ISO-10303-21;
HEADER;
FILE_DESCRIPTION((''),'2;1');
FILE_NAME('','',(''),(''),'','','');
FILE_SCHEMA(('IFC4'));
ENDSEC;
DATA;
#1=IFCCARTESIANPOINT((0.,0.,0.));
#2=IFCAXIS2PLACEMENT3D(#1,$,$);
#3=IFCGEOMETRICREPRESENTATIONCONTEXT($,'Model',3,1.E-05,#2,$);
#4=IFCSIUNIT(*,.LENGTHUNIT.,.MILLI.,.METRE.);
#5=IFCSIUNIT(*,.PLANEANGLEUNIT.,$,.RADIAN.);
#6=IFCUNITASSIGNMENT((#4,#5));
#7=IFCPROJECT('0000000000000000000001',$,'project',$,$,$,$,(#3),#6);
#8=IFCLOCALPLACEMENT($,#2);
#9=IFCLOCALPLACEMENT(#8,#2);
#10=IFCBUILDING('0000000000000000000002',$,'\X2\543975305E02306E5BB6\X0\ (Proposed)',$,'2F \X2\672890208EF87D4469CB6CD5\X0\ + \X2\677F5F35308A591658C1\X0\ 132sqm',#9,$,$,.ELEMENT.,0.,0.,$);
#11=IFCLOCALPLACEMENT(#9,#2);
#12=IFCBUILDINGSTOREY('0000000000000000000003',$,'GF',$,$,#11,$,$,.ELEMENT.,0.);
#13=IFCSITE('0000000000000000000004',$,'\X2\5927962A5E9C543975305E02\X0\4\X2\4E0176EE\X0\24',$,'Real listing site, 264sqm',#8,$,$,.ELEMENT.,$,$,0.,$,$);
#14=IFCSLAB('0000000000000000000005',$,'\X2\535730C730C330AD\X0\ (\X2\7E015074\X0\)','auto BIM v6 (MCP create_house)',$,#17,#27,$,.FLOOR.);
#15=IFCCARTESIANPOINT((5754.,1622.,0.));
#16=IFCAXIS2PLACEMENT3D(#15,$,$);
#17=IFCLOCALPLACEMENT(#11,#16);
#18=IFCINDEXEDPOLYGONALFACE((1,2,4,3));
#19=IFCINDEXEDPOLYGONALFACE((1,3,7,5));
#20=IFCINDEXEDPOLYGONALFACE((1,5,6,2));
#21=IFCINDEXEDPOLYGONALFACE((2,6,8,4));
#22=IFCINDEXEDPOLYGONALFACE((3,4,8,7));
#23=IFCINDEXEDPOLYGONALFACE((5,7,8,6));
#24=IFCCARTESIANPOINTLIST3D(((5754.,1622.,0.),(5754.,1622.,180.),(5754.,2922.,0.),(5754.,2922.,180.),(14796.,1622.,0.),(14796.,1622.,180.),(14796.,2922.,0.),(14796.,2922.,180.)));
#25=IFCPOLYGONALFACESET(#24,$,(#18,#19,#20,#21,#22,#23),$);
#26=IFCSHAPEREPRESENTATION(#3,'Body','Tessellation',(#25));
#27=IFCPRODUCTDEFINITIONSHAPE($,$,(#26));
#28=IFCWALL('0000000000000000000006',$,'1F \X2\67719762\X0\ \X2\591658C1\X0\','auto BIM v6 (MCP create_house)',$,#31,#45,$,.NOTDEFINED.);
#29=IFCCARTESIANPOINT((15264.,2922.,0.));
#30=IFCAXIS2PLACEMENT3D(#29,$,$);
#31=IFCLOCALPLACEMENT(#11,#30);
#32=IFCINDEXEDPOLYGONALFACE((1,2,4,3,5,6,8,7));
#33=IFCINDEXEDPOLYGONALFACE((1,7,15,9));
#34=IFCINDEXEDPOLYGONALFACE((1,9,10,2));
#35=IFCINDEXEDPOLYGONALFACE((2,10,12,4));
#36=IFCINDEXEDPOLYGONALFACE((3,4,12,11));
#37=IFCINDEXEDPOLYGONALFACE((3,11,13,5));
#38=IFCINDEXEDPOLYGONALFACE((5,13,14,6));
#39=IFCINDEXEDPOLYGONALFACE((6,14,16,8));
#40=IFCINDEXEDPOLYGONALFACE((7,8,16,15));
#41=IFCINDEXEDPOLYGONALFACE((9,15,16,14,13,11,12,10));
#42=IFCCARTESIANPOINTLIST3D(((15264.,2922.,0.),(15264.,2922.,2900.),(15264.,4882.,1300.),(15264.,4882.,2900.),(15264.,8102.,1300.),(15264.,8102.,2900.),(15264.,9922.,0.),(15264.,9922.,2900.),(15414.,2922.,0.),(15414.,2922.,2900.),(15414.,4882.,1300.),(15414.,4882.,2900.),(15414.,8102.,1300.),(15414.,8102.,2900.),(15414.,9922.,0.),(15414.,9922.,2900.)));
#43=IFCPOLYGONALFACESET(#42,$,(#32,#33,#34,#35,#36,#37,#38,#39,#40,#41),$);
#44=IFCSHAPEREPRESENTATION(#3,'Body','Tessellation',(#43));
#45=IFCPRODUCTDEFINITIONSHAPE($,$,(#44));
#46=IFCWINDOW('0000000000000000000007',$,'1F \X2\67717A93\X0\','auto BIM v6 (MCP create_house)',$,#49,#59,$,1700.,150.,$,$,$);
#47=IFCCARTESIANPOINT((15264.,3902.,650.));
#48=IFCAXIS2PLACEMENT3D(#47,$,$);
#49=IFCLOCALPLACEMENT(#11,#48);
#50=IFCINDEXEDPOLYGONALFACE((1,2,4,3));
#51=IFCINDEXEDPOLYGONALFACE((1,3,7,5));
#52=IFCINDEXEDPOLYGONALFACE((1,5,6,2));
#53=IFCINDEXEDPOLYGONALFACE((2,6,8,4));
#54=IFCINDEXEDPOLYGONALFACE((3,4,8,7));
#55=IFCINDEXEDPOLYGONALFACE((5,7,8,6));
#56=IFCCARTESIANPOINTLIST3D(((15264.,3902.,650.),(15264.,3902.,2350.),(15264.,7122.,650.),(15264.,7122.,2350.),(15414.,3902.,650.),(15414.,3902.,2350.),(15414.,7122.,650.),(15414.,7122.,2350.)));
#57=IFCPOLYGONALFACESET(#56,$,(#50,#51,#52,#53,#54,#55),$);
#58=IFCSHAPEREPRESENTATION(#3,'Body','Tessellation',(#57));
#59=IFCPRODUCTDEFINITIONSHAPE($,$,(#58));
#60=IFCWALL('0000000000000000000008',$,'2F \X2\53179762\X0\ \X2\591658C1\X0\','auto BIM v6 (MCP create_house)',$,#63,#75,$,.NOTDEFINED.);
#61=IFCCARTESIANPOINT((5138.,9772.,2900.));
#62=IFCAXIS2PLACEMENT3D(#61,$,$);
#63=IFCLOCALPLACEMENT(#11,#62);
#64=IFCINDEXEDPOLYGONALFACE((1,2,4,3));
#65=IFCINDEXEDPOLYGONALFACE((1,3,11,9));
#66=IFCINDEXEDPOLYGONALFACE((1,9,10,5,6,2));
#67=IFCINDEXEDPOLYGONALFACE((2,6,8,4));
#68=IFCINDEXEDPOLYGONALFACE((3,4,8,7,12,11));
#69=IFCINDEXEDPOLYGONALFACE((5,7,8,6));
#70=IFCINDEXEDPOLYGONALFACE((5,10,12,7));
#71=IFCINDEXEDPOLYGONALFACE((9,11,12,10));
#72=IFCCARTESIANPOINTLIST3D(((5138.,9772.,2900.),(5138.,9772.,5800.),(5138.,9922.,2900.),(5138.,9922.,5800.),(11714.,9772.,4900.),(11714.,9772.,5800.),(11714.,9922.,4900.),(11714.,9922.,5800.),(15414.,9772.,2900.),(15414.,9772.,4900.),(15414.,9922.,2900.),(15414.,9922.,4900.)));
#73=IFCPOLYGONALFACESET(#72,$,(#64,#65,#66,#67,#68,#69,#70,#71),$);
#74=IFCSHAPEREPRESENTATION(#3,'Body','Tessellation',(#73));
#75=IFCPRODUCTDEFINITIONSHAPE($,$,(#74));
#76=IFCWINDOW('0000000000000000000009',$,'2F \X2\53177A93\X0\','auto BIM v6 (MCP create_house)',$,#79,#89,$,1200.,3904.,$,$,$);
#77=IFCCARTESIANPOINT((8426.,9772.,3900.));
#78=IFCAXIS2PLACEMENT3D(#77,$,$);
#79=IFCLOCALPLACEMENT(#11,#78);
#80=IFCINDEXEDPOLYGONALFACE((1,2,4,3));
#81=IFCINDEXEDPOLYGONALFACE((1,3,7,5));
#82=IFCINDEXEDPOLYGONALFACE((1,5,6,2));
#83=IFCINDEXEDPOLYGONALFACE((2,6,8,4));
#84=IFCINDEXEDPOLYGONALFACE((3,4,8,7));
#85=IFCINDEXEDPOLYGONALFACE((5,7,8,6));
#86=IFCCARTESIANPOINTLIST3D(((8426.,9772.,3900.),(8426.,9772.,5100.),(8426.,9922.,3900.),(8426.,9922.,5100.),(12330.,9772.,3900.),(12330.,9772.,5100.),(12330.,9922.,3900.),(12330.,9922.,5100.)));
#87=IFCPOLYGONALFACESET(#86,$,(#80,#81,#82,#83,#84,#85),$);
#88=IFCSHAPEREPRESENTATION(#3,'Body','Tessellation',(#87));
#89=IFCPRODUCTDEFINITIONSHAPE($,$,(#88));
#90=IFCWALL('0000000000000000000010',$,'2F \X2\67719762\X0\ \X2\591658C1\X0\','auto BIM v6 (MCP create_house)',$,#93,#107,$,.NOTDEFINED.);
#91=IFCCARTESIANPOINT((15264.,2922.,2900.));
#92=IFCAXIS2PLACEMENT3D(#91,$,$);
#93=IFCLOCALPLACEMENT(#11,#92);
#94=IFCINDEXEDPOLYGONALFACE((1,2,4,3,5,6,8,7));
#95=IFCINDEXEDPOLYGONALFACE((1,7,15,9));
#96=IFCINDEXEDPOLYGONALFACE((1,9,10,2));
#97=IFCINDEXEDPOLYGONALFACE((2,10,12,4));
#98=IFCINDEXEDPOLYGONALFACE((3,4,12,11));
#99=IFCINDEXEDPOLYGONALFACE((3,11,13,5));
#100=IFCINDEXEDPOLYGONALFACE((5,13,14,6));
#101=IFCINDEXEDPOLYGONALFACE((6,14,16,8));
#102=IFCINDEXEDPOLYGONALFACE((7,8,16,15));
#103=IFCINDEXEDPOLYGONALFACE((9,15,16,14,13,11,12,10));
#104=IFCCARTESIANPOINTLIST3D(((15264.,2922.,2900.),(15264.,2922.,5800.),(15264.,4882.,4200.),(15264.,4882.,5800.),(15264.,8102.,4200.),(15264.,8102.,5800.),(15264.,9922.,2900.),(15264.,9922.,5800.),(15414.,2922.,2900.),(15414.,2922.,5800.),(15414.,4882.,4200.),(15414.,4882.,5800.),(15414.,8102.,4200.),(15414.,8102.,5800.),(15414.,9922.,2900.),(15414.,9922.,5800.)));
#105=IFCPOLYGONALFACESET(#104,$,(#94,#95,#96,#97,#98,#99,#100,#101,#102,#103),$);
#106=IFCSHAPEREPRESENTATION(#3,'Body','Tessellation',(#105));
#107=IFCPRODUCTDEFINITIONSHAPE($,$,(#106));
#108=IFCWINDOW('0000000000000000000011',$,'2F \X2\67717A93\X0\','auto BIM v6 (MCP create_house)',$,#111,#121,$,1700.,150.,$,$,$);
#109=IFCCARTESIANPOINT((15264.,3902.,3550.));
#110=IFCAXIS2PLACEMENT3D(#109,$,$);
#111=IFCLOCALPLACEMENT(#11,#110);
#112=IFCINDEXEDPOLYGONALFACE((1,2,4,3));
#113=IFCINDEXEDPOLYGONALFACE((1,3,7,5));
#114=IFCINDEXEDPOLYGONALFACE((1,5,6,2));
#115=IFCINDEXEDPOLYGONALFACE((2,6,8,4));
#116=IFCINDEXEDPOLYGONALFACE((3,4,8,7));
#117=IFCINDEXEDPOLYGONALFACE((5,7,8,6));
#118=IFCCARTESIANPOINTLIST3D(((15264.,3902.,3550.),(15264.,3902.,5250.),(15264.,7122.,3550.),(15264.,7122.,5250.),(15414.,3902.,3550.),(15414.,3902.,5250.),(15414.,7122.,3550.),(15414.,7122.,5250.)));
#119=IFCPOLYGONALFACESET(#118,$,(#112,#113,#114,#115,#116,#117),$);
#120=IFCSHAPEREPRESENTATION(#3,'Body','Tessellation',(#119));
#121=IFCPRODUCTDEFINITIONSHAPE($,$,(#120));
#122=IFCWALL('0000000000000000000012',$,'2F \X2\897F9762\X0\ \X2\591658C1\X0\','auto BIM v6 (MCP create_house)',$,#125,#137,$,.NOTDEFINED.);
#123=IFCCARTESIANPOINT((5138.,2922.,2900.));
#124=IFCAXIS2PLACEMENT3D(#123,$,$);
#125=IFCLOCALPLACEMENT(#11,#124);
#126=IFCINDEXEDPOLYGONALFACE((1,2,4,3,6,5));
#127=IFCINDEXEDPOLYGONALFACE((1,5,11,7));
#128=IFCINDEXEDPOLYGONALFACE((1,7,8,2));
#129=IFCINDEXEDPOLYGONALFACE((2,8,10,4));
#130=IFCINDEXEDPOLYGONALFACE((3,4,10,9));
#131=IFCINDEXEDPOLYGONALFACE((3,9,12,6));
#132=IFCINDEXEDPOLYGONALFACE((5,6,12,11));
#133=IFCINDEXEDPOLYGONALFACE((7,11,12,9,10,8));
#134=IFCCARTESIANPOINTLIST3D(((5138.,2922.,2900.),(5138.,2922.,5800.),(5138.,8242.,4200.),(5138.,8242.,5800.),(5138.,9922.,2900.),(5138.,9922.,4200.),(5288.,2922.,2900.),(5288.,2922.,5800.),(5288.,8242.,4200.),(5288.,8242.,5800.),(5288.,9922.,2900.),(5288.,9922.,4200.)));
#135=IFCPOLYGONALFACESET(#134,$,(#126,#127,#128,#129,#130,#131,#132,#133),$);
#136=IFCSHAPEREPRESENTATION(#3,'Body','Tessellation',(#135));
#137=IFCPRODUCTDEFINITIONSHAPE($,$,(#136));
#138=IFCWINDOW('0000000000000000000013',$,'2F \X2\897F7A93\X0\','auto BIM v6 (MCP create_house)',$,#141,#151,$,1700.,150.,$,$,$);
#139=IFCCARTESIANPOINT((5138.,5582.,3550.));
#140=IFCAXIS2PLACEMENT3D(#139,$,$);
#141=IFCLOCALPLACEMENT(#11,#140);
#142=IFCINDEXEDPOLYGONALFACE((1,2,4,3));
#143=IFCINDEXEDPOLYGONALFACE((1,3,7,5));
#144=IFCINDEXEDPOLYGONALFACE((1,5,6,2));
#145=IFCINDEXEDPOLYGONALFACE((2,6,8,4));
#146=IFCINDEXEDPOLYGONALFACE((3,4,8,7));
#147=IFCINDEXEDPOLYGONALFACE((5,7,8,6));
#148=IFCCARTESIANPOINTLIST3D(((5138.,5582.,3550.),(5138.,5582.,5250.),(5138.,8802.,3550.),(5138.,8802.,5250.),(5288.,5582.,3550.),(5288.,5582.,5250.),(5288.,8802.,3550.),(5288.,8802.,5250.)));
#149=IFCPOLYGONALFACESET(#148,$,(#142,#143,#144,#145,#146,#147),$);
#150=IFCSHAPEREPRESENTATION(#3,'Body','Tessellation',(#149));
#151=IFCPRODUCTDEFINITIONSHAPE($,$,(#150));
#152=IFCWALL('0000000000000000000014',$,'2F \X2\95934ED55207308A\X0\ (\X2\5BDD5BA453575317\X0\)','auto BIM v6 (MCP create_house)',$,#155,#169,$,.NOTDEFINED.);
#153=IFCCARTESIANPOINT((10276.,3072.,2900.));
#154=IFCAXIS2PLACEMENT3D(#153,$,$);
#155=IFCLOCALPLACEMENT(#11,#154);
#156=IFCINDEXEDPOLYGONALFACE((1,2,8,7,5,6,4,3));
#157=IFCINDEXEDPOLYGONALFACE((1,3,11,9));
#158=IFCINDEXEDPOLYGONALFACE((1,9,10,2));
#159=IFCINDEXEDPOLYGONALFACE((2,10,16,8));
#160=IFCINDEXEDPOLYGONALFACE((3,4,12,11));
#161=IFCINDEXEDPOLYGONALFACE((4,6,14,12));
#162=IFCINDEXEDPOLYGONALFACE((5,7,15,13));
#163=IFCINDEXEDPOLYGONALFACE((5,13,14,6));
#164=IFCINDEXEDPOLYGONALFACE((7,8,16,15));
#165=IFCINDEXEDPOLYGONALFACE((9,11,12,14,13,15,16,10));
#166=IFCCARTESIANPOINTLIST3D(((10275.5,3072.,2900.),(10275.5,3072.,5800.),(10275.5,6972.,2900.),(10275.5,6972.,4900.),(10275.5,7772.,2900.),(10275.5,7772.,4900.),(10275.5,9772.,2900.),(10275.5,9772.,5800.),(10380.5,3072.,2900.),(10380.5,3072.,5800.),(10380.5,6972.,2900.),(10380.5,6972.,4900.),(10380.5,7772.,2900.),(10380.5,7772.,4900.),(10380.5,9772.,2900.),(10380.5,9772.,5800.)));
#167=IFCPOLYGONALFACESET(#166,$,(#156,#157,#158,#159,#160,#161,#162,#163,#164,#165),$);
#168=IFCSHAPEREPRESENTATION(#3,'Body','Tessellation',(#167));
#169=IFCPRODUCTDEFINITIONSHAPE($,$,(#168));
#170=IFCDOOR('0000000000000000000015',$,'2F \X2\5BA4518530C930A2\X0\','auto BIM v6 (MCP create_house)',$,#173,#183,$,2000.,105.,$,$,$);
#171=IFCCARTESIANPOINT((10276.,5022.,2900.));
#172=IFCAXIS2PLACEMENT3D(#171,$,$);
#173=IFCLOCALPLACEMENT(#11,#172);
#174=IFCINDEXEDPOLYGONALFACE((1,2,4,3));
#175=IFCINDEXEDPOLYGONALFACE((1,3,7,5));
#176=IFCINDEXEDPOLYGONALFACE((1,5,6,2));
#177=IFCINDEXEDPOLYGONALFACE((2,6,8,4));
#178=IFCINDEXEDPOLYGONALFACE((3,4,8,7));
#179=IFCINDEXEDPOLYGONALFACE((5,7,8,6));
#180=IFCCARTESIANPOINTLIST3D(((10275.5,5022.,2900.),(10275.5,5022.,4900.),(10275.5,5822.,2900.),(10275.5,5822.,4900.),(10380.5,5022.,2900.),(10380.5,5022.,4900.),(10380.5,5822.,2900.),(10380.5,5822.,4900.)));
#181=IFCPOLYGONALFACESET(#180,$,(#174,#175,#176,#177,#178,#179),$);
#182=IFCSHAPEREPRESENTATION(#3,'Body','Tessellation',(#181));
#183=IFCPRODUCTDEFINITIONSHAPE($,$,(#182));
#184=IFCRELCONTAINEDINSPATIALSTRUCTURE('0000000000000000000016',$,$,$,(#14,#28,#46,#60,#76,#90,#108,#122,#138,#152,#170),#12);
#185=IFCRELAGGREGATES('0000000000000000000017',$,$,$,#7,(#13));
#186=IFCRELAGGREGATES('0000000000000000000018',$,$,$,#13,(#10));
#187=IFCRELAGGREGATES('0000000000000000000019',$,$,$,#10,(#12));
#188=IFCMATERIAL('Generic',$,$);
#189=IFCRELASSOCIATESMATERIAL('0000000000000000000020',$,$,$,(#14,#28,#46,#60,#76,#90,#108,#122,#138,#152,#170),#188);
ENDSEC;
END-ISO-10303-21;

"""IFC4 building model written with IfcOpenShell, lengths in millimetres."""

from ifc_helpers import new_model, si_unit, frame, frame_2d, origin, place, context, project, spatial, rectangle, extrude, material, element, fill, save


model = new_model("IFC4")

# Units and contexts
model_context = context("Model", 3, precision=1e-05, world=origin())
ifc_project = project(units=[si_unit("LENGTHUNIT", "METRE", prefix="MILLI"), si_unit("PLANEANGLEUNIT", "RADIAN")], contexts=[model_context])

# Site, building, storey
site_placement = place(None, origin())
site = spatial("IfcSite", under=ifc_project, at=site_placement, Name="大阪府吹田市4丁目24", ObjectType="Real listing site, 264sqm", CompositionType="ELEMENT", RefElevation=0.0)
building_placement = place(site_placement, origin())
building = spatial("IfcBuilding", under=site, at=building_placement, Name="吹田市の家 (Proposed)", ObjectType="2F 木造軸組構法 + 板張り外壁 132sqm", CompositionType="ELEMENT", ElevationOfRefHeight=0.0, ElevationOfTerrain=0.0)
storey_placement = place(building_placement, origin())
storey = spatial("IfcBuildingStorey", under=building, at=storey_placement, Name="GF", CompositionType="ELEMENT", Elevation=0.0)

# Slab
ifc_material = material(Name="Generic")
slab_placement = place(storey_placement, frame((5754.0, 1622.0, 0.0)))
element("IfcSlab", 1, at=slab_placement, inside=storey, material=ifc_material, Name="南デッキ (縁側)", Description="auto BIM v6 (MCP create_house)", PredefinedType="FLOOR", context=model_context, shape_type="SweptSolid", body=[
    extrude(rectangle(XDim=9042.0, YDim=1300.0, at=frame_2d((4521.0, 650.0))), frame((5754.0, 1622.0, 0.0)), (0.0, 0.0, 1.0), 180.0),
])

# Wall, opening, window
wall_1_placement = place(storey_placement, frame((15264.0, 2922.0, 0.0)))
wall_1 = element("IfcWall", 2, at=wall_1_placement, inside=storey, material=ifc_material, Name="1F 東面 外壁", Description="auto BIM v6 (MCP create_house)", PredefinedType="NOTDEFINED", context=model_context, shape_type="SweptSolid", body=[
    extrude(rectangle(XDim=150.0, YDim=7000.0, at=frame_2d((75.0, 3500.0))), frame((15264.0, 2922.0, 0.0)), (0.0, 0.0, 1.0), 2900.0),
])
opening_1_placement = place(storey_placement, frame((15264.0, 3902.0, 650.0)))
opening_1 = element("IfcOpeningElement", 3, at=opening_1_placement, cuts=wall_1, PredefinedType="NOTDEFINED", context=model_context, shape_type="SweptSolid", body=[
    extrude(rectangle(XDim=150.0, YDim=3220.0, at=frame_2d((75.0, 1610.0))), frame((15264.0, 3902.0, 650.0)), (0.0, 0.0, 1.0), 1700.0),
])
window_1_placement = place(storey_placement, frame((15264.0, 3902.0, 650.0)))
window_1 = element("IfcWindow", 4, at=window_1_placement, inside=storey, material=ifc_material, Name="1F 東窓", Description="auto BIM v6 (MCP create_house)", OverallHeight=1700.0, OverallWidth=150.0, context=model_context, shape_type="SweptSolid", body=[
    extrude(rectangle(XDim=150.0, YDim=3220.0, at=frame_2d((75.0, 1610.0))), frame((15264.0, 3902.0, 650.0)), (0.0, 0.0, 1.0), 1700.0),
])
fill(opening_1, window_1)

# Walls, openings, windows
wall_2_placement = place(storey_placement, frame((5138.0, 9772.0, 2900.0)))
wall_2 = element("IfcWall", 5, at=wall_2_placement, inside=storey, material=ifc_material, Name="2F 北面 外壁", Description="auto BIM v6 (MCP create_house)", PredefinedType="NOTDEFINED", context=model_context, shape_type="SweptSolid", body=[
    extrude(rectangle(XDim=10276.0, YDim=150.0, at=frame_2d((5138.0, 75.0))), frame((5138.0, 9772.0, 2900.0)), (0.0, 0.0, 1.0), 2900.0),
])
opening_2_placement = place(storey_placement, frame((8426.0, 9772.0, 3900.0)))
opening_2 = element("IfcOpeningElement", 6, at=opening_2_placement, cuts=wall_2, PredefinedType="NOTDEFINED", context=model_context, shape_type="SweptSolid", body=[
    extrude(rectangle(XDim=3904.0, YDim=150.0, at=frame_2d((1952.0, 75.0))), frame((8426.0, 9772.0, 3900.0)), (0.0, 0.0, 1.0), 1200.0),
])
window_2_placement = place(storey_placement, frame((8426.0, 9772.0, 3900.0)))
window_2 = element("IfcWindow", 7, at=window_2_placement, inside=storey, material=ifc_material, Name="2F 北窓", Description="auto BIM v6 (MCP create_house)", OverallHeight=1200.0, OverallWidth=3904.0, context=model_context, shape_type="SweptSolid", body=[
    extrude(rectangle(XDim=3904.0, YDim=150.0, at=frame_2d((1952.0, 75.0))), frame((8426.0, 9772.0, 3900.0)), (0.0, 0.0, 1.0), 1200.0),
])
fill(opening_2, window_2)
wall_3_placement = place(storey_placement, frame((15264.0, 2922.0, 2900.0)))
wall_3 = element("IfcWall", 8, at=wall_3_placement, inside=storey, material=ifc_material, Name="2F 東面 外壁", Description="auto BIM v6 (MCP create_house)", PredefinedType="NOTDEFINED", context=model_context, shape_type="SweptSolid", body=[
    extrude(rectangle(XDim=150.0, YDim=7000.0, at=frame_2d((75.0, 3500.0))), frame((15264.0, 2922.0, 2900.0)), (0.0, 0.0, 1.0), 2900.0),
])
opening_3_placement = place(storey_placement, frame((15264.0, 3902.0, 3550.0)))
opening_3 = element("IfcOpeningElement", 9, at=opening_3_placement, cuts=wall_3, PredefinedType="NOTDEFINED", context=model_context, shape_type="SweptSolid", body=[
    extrude(rectangle(XDim=150.0, YDim=3220.0, at=frame_2d((75.0, 1610.0))), frame((15264.0, 3902.0, 3550.0)), (0.0, 0.0, 1.0), 1700.0),
])
window_3_placement = place(storey_placement, frame((15264.0, 3902.0, 3550.0)))
window_3 = element("IfcWindow", 10, at=window_3_placement, inside=storey, material=ifc_material, Name="2F 東窓", Description="auto BIM v6 (MCP create_house)", OverallHeight=1700.0, OverallWidth=150.0, context=model_context, shape_type="SweptSolid", body=[
    extrude(rectangle(XDim=150.0, YDim=3220.0, at=frame_2d((75.0, 1610.0))), frame((15264.0, 3902.0, 3550.0)), (0.0, 0.0, 1.0), 1700.0),
])
fill(opening_3, window_3)
wall_4_placement = place(storey_placement, frame((5138.0, 2922.0, 2900.0)))
wall_4 = element("IfcWall", 11, at=wall_4_placement, inside=storey, material=ifc_material, Name="2F 西面 外壁", Description="auto BIM v6 (MCP create_house)", PredefinedType="NOTDEFINED", context=model_context, shape_type="SweptSolid", body=[
    extrude(rectangle(XDim=150.0, YDim=7000.0, at=frame_2d((75.0, 3500.0))), frame((5138.0, 2922.0, 2900.0)), (0.0, 0.0, 1.0), 2900.0),
])
opening_4_placement = place(storey_placement, frame((5138.0, 5582.0, 3550.0)))
opening_4 = element("IfcOpeningElement", 12, at=opening_4_placement, cuts=wall_4, PredefinedType="NOTDEFINED", context=model_context, shape_type="SweptSolid", body=[
    extrude(rectangle(XDim=150.0, YDim=3220.0, at=frame_2d((75.0, 1610.0))), frame((5138.0, 5582.0, 3550.0)), (0.0, 0.0, 1.0), 1700.0),
])
window_4_placement = place(storey_placement, frame((5138.0, 5582.0, 3550.0)))
window_4 = element("IfcWindow", 13, at=window_4_placement, inside=storey, material=ifc_material, Name="2F 西窓", Description="auto BIM v6 (MCP create_house)", OverallHeight=1700.0, OverallWidth=150.0, context=model_context, shape_type="SweptSolid", body=[
    extrude(rectangle(XDim=150.0, YDim=3220.0, at=frame_2d((75.0, 1610.0))), frame((5138.0, 5582.0, 3550.0)), (0.0, 0.0, 1.0), 1700.0),
])
fill(opening_4, window_4)

# Wall, opening, door
wall_5_placement = place(storey_placement, frame((10276.0, 3072.0, 2900.0)))
wall_5 = element("IfcWall", 14, at=wall_5_placement, inside=storey, material=ifc_material, Name="2F 間仕切り (寝室南北)", Description="auto BIM v6 (MCP create_house)", PredefinedType="NOTDEFINED", context=model_context, shape_type="SweptSolid", body=[
    extrude(rectangle(XDim=105.0, YDim=6700.0, at=frame_2d((52.0, 3350.0))), frame((10276.0, 3072.0, 2900.0)), (0.0, 0.0, 1.0), 2900.0),
])
opening_5_placement = place(storey_placement, frame((10276.0, 5022.0, 2900.0)))
opening_5 = element("IfcOpeningElement", 15, at=opening_5_placement, cuts=wall_5, PredefinedType="NOTDEFINED", context=model_context, shape_type="SweptSolid", body=[
    extrude(rectangle(XDim=105.0, YDim=800.0, at=frame_2d((52.0, 400.0))), frame((10276.0, 5022.0, 2900.0)), (0.0, 0.0, 1.0), 2000.0),
])
door_placement = place(storey_placement, frame((10276.0, 5022.0, 2900.0)))
door = element("IfcDoor", 16, at=door_placement, inside=storey, material=ifc_material, Name="2F 室内ドア", Description="auto BIM v6 (MCP create_house)", OverallHeight=2000.0, OverallWidth=105.0, context=model_context, shape_type="SweptSolid", body=[
    extrude(rectangle(XDim=105.0, YDim=800.0, at=frame_2d((52.0, 400.0))), frame((10276.0, 5022.0, 2900.0)), (0.0, 0.0, 1.0), 2000.0),
])
fill(opening_5, door)

save(model, "model.ifc")
